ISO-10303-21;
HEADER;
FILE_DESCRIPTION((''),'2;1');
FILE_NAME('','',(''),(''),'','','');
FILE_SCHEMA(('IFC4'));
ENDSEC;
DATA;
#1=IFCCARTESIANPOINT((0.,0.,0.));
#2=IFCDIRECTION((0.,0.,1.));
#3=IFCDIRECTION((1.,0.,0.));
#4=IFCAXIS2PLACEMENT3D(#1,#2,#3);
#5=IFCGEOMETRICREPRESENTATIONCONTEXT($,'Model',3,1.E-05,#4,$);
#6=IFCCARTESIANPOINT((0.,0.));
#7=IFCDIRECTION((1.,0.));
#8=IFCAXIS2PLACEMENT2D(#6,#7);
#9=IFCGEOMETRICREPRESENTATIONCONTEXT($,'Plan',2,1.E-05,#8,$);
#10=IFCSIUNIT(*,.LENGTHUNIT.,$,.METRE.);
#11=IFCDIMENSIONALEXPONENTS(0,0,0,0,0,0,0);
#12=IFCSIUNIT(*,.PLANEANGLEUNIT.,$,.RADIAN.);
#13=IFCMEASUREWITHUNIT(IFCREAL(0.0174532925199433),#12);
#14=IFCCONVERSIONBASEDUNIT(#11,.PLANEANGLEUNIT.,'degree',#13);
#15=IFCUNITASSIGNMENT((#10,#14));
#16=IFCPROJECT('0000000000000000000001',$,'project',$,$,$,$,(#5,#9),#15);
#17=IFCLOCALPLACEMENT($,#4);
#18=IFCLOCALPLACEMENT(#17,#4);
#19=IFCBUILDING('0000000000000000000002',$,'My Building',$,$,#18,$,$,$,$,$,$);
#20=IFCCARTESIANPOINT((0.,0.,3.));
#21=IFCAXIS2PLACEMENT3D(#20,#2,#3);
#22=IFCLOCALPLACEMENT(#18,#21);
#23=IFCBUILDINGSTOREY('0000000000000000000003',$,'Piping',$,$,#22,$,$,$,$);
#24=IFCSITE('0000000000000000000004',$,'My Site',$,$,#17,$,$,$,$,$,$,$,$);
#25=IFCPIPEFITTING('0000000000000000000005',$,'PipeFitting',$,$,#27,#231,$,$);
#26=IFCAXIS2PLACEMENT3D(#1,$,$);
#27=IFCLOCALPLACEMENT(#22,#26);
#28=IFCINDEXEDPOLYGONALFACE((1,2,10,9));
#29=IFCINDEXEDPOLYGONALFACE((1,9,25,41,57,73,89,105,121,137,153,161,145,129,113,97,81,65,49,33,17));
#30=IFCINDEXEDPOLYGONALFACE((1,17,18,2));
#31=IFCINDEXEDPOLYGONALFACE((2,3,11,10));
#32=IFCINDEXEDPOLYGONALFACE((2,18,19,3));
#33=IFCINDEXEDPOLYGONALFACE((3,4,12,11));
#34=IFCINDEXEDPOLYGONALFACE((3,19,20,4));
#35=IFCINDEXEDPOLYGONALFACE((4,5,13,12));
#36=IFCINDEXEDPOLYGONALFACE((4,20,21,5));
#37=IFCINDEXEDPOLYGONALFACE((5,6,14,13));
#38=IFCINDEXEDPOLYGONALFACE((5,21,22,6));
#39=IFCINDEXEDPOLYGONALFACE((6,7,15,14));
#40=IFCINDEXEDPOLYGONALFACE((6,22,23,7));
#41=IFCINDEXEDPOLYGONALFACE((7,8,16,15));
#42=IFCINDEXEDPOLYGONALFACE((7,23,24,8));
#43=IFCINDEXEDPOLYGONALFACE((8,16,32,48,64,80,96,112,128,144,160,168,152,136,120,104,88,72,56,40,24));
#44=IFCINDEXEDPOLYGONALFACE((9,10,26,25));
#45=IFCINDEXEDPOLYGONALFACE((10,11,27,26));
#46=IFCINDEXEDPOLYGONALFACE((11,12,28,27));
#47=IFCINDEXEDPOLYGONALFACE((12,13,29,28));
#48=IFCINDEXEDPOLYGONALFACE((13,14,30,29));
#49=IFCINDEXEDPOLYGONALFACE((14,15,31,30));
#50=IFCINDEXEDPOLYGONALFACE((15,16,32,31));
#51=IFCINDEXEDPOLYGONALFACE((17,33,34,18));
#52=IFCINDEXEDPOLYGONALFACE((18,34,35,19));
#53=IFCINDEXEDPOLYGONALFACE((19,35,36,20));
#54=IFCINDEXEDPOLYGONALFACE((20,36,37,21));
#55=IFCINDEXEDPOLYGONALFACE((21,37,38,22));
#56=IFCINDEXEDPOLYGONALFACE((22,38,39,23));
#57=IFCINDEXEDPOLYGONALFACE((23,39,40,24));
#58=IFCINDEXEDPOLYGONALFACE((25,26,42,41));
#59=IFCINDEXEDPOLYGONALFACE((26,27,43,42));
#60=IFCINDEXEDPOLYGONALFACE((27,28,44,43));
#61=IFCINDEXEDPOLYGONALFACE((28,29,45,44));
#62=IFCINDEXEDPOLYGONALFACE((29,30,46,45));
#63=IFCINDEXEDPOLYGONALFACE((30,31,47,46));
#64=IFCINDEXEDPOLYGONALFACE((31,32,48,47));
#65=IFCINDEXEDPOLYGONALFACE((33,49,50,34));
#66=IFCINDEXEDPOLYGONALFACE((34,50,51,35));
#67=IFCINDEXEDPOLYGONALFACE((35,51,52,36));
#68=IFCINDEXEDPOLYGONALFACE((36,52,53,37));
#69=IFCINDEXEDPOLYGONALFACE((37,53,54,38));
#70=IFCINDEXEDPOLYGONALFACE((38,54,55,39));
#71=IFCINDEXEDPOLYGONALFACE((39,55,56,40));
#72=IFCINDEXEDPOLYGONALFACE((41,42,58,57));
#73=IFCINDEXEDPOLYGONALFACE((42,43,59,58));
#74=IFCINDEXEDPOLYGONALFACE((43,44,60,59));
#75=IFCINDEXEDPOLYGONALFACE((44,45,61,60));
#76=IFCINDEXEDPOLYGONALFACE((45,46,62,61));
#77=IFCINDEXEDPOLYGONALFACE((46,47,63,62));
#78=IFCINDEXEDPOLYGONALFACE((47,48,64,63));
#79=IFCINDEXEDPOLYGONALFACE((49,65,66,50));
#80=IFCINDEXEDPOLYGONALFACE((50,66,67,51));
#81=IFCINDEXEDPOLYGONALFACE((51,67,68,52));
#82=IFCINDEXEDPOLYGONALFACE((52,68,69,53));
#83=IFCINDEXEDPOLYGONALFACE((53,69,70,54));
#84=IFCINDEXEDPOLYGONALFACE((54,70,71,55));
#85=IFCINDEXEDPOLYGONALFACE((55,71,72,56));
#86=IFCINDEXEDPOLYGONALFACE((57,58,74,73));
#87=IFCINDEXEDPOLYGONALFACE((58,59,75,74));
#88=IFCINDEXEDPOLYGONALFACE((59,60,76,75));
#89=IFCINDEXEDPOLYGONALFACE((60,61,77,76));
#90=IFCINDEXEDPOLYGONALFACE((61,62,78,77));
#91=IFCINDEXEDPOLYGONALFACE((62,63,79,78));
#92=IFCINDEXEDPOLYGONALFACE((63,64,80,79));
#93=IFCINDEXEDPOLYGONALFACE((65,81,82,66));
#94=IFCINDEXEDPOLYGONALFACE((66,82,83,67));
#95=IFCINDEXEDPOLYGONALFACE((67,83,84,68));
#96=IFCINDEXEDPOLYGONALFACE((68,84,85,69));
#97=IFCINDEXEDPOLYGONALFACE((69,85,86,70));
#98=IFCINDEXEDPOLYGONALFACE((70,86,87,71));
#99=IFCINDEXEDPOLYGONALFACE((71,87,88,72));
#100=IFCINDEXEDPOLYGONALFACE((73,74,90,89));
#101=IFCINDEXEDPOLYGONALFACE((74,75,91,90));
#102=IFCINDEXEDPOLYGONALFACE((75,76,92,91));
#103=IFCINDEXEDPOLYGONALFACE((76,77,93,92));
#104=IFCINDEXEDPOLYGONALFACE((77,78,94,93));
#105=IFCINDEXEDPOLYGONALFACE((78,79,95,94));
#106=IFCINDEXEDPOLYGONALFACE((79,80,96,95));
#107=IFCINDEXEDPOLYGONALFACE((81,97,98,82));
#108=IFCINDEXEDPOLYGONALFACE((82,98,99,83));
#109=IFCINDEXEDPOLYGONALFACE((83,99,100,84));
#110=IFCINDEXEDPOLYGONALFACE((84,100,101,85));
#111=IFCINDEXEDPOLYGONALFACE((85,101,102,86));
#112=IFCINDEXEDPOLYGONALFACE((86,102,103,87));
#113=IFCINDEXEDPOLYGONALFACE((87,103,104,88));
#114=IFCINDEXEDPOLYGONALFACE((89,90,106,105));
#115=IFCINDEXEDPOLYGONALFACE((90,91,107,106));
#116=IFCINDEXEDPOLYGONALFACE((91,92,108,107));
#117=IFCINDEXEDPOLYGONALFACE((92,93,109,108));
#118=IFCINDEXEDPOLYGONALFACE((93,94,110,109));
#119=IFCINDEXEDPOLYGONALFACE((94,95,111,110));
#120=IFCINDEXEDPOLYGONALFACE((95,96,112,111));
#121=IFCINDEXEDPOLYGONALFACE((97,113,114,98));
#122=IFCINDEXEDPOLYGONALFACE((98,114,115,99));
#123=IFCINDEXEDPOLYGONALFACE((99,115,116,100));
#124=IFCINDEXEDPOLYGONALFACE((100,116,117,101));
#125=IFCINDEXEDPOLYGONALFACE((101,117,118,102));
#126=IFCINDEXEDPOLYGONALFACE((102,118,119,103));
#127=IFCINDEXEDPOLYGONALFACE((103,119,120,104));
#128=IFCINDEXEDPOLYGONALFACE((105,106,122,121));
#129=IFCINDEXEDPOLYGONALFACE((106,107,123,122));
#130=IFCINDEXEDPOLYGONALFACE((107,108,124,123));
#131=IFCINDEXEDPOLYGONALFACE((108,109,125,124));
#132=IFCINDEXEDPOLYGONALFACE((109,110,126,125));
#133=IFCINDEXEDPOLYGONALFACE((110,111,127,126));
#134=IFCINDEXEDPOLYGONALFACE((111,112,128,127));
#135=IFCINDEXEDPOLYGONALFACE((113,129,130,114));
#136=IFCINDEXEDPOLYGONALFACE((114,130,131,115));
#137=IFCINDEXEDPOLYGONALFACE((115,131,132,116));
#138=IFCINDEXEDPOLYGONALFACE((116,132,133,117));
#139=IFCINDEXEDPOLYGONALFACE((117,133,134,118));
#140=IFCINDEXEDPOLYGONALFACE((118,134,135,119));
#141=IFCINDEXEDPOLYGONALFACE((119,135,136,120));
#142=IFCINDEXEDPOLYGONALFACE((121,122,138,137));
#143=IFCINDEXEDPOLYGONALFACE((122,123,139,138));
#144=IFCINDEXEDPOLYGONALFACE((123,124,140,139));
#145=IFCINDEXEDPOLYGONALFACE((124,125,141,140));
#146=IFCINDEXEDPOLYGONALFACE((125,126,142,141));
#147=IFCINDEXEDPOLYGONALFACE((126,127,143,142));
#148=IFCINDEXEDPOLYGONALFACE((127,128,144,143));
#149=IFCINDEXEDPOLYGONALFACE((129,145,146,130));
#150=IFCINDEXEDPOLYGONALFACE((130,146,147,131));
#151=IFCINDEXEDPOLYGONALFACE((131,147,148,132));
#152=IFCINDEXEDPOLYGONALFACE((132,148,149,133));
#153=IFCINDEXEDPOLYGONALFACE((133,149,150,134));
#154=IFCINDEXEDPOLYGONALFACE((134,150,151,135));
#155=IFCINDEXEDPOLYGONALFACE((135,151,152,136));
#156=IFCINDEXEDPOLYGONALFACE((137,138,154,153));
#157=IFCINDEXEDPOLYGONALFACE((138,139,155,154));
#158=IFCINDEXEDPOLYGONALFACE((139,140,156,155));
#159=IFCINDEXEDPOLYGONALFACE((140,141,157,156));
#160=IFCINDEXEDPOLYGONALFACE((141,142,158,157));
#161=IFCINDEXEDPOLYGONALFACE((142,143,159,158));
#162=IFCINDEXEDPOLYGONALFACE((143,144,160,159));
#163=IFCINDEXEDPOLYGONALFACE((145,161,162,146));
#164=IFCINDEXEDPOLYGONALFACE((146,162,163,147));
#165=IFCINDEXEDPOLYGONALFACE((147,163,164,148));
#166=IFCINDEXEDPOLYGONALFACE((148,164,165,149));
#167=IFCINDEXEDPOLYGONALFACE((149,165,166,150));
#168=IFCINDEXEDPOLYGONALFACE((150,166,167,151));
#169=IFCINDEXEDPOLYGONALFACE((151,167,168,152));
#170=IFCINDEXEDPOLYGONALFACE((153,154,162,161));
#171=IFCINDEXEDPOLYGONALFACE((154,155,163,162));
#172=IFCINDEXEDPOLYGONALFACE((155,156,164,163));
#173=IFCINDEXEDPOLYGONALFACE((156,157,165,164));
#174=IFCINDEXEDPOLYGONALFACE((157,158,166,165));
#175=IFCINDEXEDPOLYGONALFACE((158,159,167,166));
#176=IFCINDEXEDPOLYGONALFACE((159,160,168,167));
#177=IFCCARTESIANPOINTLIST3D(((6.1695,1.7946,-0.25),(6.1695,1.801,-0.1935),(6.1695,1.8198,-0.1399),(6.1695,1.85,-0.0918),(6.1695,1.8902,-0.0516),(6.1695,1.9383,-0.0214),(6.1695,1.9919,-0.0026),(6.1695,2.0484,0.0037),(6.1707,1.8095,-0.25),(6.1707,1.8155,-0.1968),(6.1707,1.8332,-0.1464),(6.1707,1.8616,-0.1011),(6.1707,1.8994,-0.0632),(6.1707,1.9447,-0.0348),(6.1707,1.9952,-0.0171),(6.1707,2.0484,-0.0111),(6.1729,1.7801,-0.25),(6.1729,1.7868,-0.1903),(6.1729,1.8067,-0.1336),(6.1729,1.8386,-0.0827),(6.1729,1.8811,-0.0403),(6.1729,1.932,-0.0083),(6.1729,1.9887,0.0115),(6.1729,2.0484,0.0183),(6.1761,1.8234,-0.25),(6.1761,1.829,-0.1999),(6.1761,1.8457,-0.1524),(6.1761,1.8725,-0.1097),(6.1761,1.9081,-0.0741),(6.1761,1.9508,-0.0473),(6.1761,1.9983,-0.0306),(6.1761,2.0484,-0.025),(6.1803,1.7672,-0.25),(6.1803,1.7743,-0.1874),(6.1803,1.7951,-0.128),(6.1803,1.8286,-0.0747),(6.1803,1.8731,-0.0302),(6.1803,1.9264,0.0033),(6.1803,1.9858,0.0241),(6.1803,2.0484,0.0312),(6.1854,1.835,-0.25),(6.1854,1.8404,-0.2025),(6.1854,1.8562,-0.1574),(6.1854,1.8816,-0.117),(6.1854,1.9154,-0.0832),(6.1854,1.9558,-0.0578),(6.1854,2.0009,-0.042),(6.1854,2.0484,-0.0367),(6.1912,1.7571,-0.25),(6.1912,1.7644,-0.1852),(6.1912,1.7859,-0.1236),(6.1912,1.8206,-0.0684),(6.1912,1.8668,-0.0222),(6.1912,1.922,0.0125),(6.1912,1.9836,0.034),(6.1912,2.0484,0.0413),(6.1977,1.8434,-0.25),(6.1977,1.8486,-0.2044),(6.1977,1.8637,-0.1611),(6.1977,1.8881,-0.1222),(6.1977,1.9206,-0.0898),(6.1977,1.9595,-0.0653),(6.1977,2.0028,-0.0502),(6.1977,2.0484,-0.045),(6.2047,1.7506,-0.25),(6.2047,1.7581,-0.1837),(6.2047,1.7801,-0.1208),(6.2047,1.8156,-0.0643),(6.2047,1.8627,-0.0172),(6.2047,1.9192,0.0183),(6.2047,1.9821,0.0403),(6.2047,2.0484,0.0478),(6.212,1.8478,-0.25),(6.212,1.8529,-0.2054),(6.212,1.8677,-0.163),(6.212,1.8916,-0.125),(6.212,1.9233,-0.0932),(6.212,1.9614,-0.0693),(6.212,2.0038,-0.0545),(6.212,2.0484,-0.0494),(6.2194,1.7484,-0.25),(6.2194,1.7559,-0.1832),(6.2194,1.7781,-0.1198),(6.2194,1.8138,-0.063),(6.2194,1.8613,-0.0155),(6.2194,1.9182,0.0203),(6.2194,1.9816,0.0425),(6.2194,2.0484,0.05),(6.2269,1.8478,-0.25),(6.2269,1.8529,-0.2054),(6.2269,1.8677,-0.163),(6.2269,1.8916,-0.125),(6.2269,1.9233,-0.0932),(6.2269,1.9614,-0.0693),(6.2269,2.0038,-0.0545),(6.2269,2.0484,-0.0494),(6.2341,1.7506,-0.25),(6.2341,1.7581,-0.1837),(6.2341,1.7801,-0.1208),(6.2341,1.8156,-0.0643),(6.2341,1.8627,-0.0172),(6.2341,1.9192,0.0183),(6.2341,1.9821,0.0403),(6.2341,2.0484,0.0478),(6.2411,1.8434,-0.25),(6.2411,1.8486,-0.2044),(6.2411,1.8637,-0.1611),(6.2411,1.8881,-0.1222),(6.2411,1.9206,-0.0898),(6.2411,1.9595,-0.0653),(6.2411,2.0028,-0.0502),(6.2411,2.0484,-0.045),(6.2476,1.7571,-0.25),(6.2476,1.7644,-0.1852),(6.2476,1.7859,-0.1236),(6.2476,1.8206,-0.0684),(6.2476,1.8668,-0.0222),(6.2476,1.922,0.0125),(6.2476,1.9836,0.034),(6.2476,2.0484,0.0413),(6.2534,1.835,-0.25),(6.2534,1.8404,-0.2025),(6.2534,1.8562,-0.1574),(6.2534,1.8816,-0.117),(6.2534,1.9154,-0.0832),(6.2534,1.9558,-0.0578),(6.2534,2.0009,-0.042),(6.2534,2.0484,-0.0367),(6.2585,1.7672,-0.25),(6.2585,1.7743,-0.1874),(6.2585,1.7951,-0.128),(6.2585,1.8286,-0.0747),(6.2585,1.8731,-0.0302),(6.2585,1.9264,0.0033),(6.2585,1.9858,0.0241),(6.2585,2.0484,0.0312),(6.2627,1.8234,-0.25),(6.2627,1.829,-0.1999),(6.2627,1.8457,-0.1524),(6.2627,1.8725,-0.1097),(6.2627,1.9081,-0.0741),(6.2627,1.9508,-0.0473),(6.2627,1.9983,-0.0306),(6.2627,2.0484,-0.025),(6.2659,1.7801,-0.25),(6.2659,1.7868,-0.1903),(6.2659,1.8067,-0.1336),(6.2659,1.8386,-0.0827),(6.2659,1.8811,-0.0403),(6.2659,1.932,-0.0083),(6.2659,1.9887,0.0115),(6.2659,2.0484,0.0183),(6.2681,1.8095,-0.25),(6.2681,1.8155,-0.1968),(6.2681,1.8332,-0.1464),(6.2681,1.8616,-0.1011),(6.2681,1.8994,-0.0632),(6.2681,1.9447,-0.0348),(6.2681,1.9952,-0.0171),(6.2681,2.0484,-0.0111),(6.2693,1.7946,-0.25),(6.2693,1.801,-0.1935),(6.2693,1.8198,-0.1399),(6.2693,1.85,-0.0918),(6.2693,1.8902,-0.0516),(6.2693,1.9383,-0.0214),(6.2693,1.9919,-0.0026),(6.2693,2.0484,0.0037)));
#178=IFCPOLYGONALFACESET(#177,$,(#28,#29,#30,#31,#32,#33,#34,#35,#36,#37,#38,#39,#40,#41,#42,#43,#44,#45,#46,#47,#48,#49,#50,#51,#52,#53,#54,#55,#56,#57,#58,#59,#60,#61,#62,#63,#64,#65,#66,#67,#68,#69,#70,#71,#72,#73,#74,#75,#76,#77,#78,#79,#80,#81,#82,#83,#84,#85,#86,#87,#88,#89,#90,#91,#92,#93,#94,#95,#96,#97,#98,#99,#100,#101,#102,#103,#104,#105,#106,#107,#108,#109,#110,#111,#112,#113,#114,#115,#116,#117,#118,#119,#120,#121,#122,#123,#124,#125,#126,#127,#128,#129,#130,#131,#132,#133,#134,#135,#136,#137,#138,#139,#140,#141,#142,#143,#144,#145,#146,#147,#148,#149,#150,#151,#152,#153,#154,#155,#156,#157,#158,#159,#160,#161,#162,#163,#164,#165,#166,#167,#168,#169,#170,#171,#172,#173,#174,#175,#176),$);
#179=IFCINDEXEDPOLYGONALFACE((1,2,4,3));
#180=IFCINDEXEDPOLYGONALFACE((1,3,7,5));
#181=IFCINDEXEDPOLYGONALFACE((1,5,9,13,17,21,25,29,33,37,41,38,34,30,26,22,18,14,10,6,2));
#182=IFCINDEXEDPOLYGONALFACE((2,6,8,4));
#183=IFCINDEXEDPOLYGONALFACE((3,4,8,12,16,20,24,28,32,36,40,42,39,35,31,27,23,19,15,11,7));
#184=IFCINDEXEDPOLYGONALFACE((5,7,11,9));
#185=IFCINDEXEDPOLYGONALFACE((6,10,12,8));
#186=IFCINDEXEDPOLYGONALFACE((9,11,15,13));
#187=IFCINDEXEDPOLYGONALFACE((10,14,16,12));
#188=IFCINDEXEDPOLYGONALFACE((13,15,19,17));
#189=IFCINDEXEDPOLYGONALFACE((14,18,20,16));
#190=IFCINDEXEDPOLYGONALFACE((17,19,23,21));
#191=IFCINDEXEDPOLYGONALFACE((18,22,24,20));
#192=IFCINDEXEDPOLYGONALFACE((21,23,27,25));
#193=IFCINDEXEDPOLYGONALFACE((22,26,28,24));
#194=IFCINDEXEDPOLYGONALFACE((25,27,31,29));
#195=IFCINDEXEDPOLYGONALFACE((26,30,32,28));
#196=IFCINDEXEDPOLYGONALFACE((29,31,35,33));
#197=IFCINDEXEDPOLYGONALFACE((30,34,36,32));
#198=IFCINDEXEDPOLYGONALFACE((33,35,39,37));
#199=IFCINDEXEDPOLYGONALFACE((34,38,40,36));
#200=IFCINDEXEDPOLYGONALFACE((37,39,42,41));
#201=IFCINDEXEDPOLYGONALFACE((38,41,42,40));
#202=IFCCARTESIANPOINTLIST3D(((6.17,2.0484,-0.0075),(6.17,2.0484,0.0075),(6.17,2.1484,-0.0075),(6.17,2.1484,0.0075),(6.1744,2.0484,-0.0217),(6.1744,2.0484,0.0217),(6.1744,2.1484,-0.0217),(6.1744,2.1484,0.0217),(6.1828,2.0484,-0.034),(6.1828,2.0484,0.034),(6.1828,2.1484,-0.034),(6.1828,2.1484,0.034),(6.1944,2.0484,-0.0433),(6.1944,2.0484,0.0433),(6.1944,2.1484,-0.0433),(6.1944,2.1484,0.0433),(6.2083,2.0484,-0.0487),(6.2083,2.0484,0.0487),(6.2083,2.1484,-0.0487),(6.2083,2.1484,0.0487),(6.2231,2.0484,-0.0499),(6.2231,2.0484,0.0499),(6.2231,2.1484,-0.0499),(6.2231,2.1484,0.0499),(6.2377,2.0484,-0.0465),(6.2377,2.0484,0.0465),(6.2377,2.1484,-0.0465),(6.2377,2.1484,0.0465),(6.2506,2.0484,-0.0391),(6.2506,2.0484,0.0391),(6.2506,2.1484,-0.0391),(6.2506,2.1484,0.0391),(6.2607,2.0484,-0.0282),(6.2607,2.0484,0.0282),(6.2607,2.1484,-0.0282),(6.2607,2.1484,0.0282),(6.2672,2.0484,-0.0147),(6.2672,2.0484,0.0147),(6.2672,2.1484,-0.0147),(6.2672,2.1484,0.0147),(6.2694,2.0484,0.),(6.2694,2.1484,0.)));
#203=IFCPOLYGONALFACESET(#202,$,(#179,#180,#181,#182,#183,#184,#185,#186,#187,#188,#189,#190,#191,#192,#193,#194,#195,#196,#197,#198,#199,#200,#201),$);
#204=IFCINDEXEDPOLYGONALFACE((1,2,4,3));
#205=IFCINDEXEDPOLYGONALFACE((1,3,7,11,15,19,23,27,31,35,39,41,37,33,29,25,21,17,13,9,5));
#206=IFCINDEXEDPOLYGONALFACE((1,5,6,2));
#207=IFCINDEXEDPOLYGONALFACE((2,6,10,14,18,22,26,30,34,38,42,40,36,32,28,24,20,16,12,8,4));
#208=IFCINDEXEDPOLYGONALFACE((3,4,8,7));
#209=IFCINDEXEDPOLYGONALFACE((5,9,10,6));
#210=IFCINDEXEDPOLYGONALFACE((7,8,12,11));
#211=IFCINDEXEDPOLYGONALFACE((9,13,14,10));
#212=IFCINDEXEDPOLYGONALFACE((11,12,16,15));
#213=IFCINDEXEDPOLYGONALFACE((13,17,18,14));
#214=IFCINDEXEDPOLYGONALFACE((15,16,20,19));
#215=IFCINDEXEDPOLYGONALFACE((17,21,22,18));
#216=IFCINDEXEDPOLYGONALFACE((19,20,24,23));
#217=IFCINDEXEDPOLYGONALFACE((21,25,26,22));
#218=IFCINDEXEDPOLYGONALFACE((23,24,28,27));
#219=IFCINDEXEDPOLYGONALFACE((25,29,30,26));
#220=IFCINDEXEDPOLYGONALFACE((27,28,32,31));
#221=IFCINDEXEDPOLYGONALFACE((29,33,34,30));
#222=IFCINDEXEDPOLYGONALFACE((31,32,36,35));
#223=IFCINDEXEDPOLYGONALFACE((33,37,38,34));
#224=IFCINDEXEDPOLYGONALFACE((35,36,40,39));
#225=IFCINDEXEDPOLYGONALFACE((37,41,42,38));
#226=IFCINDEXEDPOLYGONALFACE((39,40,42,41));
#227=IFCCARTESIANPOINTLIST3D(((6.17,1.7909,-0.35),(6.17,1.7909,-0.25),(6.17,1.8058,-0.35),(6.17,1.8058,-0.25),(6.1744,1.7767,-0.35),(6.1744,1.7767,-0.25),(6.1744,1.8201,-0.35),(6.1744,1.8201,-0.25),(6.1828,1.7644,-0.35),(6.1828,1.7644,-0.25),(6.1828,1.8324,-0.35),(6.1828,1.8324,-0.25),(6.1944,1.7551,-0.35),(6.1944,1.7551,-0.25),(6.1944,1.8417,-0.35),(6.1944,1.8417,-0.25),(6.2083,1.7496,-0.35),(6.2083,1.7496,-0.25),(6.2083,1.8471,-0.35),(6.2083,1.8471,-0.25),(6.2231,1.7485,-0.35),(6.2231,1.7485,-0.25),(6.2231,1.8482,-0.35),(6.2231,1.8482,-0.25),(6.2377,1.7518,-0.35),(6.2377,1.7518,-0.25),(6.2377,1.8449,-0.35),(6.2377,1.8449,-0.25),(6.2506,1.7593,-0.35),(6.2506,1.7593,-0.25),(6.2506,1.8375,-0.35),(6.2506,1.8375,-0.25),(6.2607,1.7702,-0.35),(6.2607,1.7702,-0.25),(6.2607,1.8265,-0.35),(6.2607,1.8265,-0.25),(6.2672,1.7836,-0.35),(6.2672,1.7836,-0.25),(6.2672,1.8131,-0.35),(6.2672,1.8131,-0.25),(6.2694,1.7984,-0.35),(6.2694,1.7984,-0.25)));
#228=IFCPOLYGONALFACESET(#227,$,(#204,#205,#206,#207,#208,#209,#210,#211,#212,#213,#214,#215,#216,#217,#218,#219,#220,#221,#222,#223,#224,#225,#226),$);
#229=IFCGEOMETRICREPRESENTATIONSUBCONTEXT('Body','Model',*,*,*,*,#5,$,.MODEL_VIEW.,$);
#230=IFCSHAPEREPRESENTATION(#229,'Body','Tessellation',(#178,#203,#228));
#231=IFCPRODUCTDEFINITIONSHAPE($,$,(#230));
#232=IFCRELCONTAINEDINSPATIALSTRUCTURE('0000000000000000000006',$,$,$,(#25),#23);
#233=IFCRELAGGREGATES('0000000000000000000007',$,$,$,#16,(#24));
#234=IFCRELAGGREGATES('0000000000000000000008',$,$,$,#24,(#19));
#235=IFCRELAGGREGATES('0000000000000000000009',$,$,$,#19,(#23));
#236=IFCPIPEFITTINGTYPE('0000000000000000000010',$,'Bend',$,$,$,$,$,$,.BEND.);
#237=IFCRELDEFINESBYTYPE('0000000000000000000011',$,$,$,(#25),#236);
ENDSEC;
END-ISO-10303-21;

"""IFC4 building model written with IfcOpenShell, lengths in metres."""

from ifc_helpers import new_model, entity, si_unit, converted_unit, frame, origin_with_axes, origin_2d_with_axis, place, context, subcontext, project, spatial, line, indexed_curve, circle, outline, extrude, source, transform, mapped, type_object, type_shapes, element, save


model = new_model("IFC4")

# Units and contexts
model_context = context("Model", 3, precision=1e-05, world=origin_with_axes())
plan_context = context("Plan", 2, precision=1e-05, world=origin_2d_with_axis())
body_context = subcontext(model_context, "Body", "Model", "MODEL_VIEW")
ifc_project = project(units=[si_unit("LENGTHUNIT", "METRE"), converted_unit("PLANEANGLEUNIT", "degree", entity("IfcReal", 0.0174532925199433), si_unit("PLANEANGLEUNIT", "RADIAN"), dimensions=[0, 0, 0, 0, 0, 0, 0])], contexts=[model_context, plan_context])

# Site, building, storey
site_placement = place(None, origin_with_axes())
site = spatial("IfcSite", under=ifc_project, at=site_placement, Name="My Site")
building_placement = place(site_placement, origin_with_axes())
building = spatial("IfcBuilding", under=site, at=building_placement, Name="My Building")
storey_placement = place(building_placement, frame((0.0, 0.0, 3.0), z_axis=(0.0, 0.0, 1.0), x_axis=(1.0, 0.0, 0.0)))
storey = spatial("IfcBuildingStorey", under=building, at=storey_placement, Name="Piping")

# Pipe fitting, opening
pipe_fitting_type = type_object("IfcPipeFittingType", Name="Bend", PredefinedType="BEND")
shared_shape = source(origin_with_axes(), body_context, "Body", "SolidModel", [
    entity("IfcSweptDiskSolid", entity("IfcIndexedPolyCurve", entity("IfcCartesianPointList3D", [[0.0, 0.0, 0.1], [0.0, -0.0732, 0.2768], [0.0, -0.25, 0.35]]), [entity("IfcArcIndex", [1, 2, 3])]), 0.05),
    extrude(circle(Radius=0.05), origin_with_axes(), (0.0, 0.0, 1.0), 0.1),
    extrude(circle(Radius=0.05), frame((0.0, -0.25, 0.35), z_axis=(0.0, -1.0, 0.0), x_axis=(1.0, 0.0, 0.0)), (0.0, 0.0, 1.0), 0.1),
])
type_shapes(pipe_fitting_type, [shared_shape])
pipe_fitting_1_placement = place(storey_placement, frame((6.2194, 2.1484, 0.0), z_axis=(0.0, -1.0, 0.0), x_axis=(1.0, 0.0, 0.0)))
pipe_fitting_1 = element("IfcPipeFitting", 1, at=pipe_fitting_1_placement, inside=storey, type_object=pipe_fitting_type, Name="PipeFitting", context=body_context, shape_type="MappedRepresentation", body=[
    mapped(shared_shape, transform((0.0, 0.0, 0.0), x_axis=(1.0, 0.0, 0.0), y_axis=(0.0, 1.0, 0.0), z_axis=(0.0, 0.0, 1.0), scale=1.0)),
])
opening_1_placement = place(pipe_fitting_1_placement, frame((-6.2194, -3.0, 2.1484), z_axis=(0.0, 1.0, 0.0), x_axis=(1.0, 0.0, 0.0)))
element("IfcOpeningElement", 2, at=opening_1_placement, cuts=pipe_fitting_1, PredefinedType="OPENING", context=body_context, shape_type="SweptSolid", body=[
    extrude(outline(indexed_curve([(0.0, 0.0), (0.5, 0.0), (0.5, 0.5), (0.0, 0.5)], segments=[line(1, 2, 3, 4, 1)])), origin_with_axes(), (0.0, 0.0, 1.0), 0.5),
])

save(model, "model.ifc")
